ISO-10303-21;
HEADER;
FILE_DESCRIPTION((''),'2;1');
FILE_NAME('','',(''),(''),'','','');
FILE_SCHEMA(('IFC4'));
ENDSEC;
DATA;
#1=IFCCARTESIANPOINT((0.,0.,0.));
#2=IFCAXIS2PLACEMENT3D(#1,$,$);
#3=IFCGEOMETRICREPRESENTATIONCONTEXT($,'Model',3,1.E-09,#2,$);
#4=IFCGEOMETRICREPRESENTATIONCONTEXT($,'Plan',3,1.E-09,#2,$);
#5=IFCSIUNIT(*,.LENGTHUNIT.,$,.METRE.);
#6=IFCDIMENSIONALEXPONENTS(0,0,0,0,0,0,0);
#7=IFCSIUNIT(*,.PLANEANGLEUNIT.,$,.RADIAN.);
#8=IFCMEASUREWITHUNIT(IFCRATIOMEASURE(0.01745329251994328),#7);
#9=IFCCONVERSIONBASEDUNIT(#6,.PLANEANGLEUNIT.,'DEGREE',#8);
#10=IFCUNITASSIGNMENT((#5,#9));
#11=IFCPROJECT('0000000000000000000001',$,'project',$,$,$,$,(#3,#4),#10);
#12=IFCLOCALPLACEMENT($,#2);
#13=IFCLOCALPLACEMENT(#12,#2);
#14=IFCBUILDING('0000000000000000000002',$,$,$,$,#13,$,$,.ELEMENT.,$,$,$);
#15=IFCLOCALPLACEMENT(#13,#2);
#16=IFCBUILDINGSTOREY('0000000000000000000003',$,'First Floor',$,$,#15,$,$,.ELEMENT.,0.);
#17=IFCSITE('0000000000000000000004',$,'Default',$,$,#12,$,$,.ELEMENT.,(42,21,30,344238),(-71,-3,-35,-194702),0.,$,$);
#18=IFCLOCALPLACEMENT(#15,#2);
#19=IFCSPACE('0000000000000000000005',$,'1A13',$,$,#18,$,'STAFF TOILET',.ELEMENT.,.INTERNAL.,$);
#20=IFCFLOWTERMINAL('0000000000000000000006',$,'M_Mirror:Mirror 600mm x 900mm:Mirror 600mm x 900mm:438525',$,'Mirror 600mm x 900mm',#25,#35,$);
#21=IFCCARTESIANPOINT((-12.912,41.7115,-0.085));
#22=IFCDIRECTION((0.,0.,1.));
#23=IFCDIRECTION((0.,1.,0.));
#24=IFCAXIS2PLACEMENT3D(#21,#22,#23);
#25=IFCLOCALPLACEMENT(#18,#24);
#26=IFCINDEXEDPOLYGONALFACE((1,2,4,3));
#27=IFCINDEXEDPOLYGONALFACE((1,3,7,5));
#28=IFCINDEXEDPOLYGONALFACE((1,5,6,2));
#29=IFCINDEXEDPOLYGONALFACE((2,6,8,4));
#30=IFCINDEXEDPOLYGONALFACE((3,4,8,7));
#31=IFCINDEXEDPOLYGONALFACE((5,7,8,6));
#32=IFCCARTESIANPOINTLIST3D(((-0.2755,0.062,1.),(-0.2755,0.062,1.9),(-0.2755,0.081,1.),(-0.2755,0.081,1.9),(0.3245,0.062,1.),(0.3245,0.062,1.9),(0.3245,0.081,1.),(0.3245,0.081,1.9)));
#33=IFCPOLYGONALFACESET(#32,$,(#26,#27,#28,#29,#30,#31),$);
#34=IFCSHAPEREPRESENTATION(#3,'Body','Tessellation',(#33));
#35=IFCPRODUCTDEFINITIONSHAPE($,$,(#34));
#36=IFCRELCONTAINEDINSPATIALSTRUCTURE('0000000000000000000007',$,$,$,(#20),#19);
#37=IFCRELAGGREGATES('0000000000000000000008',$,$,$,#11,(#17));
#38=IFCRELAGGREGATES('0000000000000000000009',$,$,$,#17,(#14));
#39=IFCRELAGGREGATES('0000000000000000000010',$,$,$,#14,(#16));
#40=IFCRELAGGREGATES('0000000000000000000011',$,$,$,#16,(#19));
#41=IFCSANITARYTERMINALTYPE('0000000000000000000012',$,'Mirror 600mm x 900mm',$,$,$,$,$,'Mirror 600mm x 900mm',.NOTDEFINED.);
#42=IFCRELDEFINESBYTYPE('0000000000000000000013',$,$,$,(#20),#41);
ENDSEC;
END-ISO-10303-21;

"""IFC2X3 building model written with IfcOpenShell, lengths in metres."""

from ifc_helpers import new_model, entity, si_unit, converted_unit, frame, origin, origin_2d_with_axis, place, context, project, spatial, rectangle, extrude, source, transform, mapped, type_object, type_shapes, element, save


model = new_model("IFC2X3")

# Units and contexts
model_context = context("Model", 3, precision=1e-09, world=origin())
plan_context = context("Plan", 3, precision=1e-09, world=origin())
ifc_project = project(units=[si_unit("LENGTHUNIT", "METRE"), converted_unit("PLANEANGLEUNIT", "DEGREE", entity("IfcRatioMeasure", 0.01745329251994328), si_unit("PLANEANGLEUNIT", "RADIAN"), dimensions=[0, 0, 0, 0, 0, 0, 0])], contexts=[model_context, plan_context])

# Site, building, storey
site_placement = place(None, origin())
site = spatial("IfcSite", under=ifc_project, at=site_placement, Name="Default", CompositionType="ELEMENT", RefLatitude=(42, 21, 30, 344238), RefLongitude=(-71, -3, -35, -194702), RefElevation=0.0)
building_placement = place(site_placement, origin())
building = spatial("IfcBuilding", under=site, at=building_placement, CompositionType="ELEMENT")
storey_placement = place(building_placement, origin())
storey = spatial("IfcBuildingStorey", under=building, at=storey_placement, Name="First Floor", CompositionType="ELEMENT", Elevation=0.0)

# Shared definitions
space_1_placement = place(storey_placement, origin())
space_1 = spatial("IfcSpace", under=storey, at=space_1_placement, Name="1A13", LongName="STAFF TOILET", CompositionType="ELEMENT", InteriorOrExteriorSpace="INTERNAL")

# Flow terminal
sanitary_terminal_type_1 = type_object("IfcSanitaryTerminalType", Name="Mirror 600mm x 900mm", ElementType="Mirror 600mm x 900mm", PredefinedType="NOTDEFINED")
shared_shape_1 = source(origin(), model_context, "Body", "SweptSolid", [
    extrude(rectangle(XDim=0.0191, YDim=0.6, at=origin_2d_with_axis()), frame((0.0245, 0.0715, 1.0), z_axis=(0.0, 0.0, 1.0), x_axis=(0.0, -1.0, 0.0)), (0.0, 0.0, 1.0), 0.9),
])
type_shapes(sanitary_terminal_type_1, [shared_shape_1])
flow_terminal_1_placement = place(space_1_placement, frame((-12.912, 41.7115, -0.085), z_axis=(0.0, 0.0, 1.0), x_axis=(0.0, 1.0, 0.0)))
element("IfcFlowTerminal", 1, at=flow_terminal_1_placement, inside=space_1, type_object=sanitary_terminal_type_1, Name="M_Mirror:Mirror 600mm x 900mm:Mirror 600mm x 900mm:438525", ObjectType="Mirror 600mm x 900mm", context=model_context, shape_type="MappedRepresentation", body=[
    mapped(shared_shape_1, transform((0.0, 0.0, 0.0), scale=1.0)),
])

save(model, "model.ifc")
